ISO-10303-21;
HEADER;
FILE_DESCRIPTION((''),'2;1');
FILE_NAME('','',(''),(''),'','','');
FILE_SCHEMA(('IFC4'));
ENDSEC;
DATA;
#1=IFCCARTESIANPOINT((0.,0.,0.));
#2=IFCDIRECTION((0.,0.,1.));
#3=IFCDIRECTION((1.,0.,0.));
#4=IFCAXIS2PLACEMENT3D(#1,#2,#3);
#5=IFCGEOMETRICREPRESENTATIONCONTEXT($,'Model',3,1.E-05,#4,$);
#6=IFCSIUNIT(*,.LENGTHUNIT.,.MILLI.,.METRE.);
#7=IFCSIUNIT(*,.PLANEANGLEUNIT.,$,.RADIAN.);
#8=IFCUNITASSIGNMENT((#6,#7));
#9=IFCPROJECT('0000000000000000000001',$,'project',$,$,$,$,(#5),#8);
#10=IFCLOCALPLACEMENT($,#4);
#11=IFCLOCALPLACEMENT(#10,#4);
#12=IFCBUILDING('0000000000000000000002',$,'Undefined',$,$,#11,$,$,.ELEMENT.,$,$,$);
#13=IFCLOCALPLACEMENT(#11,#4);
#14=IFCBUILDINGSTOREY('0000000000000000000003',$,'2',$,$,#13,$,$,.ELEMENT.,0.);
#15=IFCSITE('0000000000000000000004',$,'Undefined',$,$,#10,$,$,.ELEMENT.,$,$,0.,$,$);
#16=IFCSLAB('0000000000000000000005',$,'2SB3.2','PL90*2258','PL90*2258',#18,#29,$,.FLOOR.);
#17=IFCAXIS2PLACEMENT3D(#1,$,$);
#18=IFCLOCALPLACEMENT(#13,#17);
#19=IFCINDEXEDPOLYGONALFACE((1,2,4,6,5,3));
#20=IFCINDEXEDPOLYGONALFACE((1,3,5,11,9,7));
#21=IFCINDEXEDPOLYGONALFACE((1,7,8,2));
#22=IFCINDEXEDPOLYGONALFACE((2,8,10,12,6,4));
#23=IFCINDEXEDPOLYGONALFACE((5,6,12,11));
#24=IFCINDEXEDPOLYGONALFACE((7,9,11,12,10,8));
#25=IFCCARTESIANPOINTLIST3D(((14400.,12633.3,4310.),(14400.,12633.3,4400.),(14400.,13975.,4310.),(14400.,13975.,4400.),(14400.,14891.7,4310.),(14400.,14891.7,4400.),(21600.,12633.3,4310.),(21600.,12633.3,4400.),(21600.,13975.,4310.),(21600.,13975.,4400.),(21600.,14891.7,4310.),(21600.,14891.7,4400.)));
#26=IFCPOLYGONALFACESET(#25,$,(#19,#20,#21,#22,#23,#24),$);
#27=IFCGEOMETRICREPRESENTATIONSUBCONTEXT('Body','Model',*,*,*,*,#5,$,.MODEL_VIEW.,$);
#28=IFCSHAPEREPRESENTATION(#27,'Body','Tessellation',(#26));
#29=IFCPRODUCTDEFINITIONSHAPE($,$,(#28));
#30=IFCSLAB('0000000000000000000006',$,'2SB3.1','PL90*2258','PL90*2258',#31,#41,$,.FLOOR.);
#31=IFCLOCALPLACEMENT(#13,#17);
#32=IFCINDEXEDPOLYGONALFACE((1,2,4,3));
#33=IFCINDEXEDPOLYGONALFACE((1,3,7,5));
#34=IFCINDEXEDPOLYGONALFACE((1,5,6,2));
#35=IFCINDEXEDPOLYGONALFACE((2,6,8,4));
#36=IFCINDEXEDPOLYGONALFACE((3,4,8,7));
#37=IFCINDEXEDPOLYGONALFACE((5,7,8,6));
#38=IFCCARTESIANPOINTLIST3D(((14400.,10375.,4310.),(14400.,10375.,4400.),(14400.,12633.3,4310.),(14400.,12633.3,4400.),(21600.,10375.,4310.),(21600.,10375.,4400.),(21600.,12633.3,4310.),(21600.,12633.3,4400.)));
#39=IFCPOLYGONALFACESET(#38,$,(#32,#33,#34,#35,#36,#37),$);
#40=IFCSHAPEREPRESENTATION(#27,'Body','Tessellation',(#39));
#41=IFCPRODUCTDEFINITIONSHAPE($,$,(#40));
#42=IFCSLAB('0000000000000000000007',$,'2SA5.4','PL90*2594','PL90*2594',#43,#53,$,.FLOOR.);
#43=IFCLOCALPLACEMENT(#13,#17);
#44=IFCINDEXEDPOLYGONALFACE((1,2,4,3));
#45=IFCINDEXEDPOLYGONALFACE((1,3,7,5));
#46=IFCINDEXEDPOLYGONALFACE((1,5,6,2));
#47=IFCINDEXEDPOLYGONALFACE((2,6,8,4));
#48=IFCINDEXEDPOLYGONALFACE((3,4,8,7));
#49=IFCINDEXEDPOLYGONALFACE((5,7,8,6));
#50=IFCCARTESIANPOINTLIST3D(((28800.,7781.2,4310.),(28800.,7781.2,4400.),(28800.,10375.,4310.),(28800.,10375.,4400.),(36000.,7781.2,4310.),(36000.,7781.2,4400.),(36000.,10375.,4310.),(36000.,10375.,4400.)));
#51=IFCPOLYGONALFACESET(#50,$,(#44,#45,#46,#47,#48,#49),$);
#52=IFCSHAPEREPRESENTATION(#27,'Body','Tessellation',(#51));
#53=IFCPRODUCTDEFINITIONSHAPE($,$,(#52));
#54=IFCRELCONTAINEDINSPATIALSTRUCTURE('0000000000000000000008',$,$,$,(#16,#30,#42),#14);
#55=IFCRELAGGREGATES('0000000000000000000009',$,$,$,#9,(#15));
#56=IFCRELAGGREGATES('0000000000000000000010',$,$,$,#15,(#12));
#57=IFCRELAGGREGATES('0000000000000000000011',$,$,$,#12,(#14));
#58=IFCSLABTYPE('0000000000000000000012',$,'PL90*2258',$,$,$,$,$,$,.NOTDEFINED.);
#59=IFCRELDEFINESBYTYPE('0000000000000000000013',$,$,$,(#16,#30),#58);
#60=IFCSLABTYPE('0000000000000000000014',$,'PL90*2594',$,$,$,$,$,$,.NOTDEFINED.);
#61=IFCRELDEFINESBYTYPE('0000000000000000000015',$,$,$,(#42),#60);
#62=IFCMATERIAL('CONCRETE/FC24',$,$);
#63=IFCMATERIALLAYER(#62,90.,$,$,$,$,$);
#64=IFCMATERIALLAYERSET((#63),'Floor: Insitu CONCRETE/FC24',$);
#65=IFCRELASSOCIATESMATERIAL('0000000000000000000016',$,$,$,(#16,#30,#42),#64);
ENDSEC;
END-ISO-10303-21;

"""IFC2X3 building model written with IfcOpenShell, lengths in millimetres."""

from ifc_helpers import new_model, si_unit, frame, origin_with_axes, place, context, subcontext, project, spatial, polyline, outline, extrude, material, layer, layer_set, layer_usage, type_object, element, save


model = new_model("IFC2X3")

# Units and contexts
model_context = context("Model", 3, precision=1e-05, world=origin_with_axes())
body_context = subcontext(model_context, "Body", "Model", "MODEL_VIEW")
ifc_project = project(units=[si_unit("LENGTHUNIT", "METRE", prefix="MILLI"), si_unit("PLANEANGLEUNIT", "RADIAN")], contexts=[model_context])

# Site, building, storey
site_placement = place(None, origin_with_axes())
site = spatial("IfcSite", under=ifc_project, at=site_placement, Name="Undefined", CompositionType="ELEMENT", RefElevation=0.0)
building_placement = place(site_placement, origin_with_axes())
building = spatial("IfcBuilding", under=site, at=building_placement, Name="Undefined", CompositionType="ELEMENT")
storey_placement = place(building_placement, origin_with_axes())
storey = spatial("IfcBuildingStorey", under=building, at=storey_placement, Name="2", CompositionType="ELEMENT", Elevation=0.0)

# Slabs
ifc_material_1 = material(Name="CONCRETE/FC24")
ifc_layer = layer(ifc_material_1, 90.0)
ifc_layer_set = layer_set([ifc_layer], Name="Floor: Insitu CONCRETE/FC24")
slab_type_1 = type_object("IfcSlabType", Name="PL90*2258", PredefinedType="NOTDEFINED")
ifc_layer_usage_1 = layer_usage(ifc_layer_set, "AXIS3", "POSITIVE", -45.0)
slab_1_placement = place(storey_placement, frame((14400.0, 12633.3, 4355.0), z_axis=(0.0, 0.0, 1.0), x_axis=(1.0, 0.0, 0.0)))
element("IfcSlab", 1, at=slab_1_placement, inside=storey, type_object=slab_type_1, material=ifc_layer_usage_1, Name="2SB3.2", Description="PL90*2258", ObjectType="PL90*2258", PredefinedType="FLOOR", context=body_context, shape_type="SweptSolid", body=[
    extrude(outline(polyline([(0.0, 0.0), (7200.0, 0.0), (7200.0, 1341.7), (7200.0, 2258.4), (0.0, 2258.4), (0.0, 1341.7), (0.0, 0.0)])), frame((0.0, 0.0, -45.0), z_axis=(0.0, 0.0, 1.0), x_axis=(1.0, 0.0, 0.0)), (0.0, 0.0, 1.0), 90.0),
])
ifc_layer_usage_2 = layer_usage(ifc_layer_set, "AXIS3", "POSITIVE", -45.0)
slab_2_placement = place(storey_placement, frame((14400.0, 10375.0, 4355.0), z_axis=(0.0, 0.0, 1.0), x_axis=(1.0, 0.0, 0.0)))
element("IfcSlab", 2, at=slab_2_placement, inside=storey, type_object=slab_type_1, material=ifc_layer_usage_2, Name="2SB3.1", Description="PL90*2258", ObjectType="PL90*2258", PredefinedType="FLOOR", context=body_context, shape_type="SweptSolid", body=[
    extrude(outline(polyline([(0.0, 0.0), (7200.0, 0.0), (7200.0, 2258.3), (0.0, 2258.3), (0.0, 0.0)])), frame((0.0, 0.0, -45.0), z_axis=(0.0, 0.0, 1.0), x_axis=(1.0, 0.0, 0.0)), (0.0, 0.0, 1.0), 90.0),
])
ifc_layer_usage_3 = layer_usage(ifc_layer_set, "AXIS3", "POSITIVE", -45.0)
slab_type_2 = type_object("IfcSlabType", Name="PL90*2594", PredefinedType="NOTDEFINED")
slab_3_placement = place(storey_placement, frame((28800.0, 7781.2, 4355.0), z_axis=(0.0, 0.0, 1.0), x_axis=(1.0, 0.0, 0.0)))
element("IfcSlab", 3, at=slab_3_placement, inside=storey, type_object=slab_type_2, material=ifc_layer_usage_3, Name="2SA5.4", Description="PL90*2594", ObjectType="PL90*2594", PredefinedType="FLOOR", context=body_context, shape_type="SweptSolid", body=[
    extrude(outline(polyline([(0.0, 0.0), (7200.0, 0.0), (7200.0, 2593.8), (0.0, 2593.8), (0.0, 0.0)])), frame((0.0, 0.0, -45.0), z_axis=(0.0, 0.0, 1.0), x_axis=(1.0, 0.0, 0.0)), (0.0, 0.0, 1.0), 90.0),
])

save(model, "model.ifc")
